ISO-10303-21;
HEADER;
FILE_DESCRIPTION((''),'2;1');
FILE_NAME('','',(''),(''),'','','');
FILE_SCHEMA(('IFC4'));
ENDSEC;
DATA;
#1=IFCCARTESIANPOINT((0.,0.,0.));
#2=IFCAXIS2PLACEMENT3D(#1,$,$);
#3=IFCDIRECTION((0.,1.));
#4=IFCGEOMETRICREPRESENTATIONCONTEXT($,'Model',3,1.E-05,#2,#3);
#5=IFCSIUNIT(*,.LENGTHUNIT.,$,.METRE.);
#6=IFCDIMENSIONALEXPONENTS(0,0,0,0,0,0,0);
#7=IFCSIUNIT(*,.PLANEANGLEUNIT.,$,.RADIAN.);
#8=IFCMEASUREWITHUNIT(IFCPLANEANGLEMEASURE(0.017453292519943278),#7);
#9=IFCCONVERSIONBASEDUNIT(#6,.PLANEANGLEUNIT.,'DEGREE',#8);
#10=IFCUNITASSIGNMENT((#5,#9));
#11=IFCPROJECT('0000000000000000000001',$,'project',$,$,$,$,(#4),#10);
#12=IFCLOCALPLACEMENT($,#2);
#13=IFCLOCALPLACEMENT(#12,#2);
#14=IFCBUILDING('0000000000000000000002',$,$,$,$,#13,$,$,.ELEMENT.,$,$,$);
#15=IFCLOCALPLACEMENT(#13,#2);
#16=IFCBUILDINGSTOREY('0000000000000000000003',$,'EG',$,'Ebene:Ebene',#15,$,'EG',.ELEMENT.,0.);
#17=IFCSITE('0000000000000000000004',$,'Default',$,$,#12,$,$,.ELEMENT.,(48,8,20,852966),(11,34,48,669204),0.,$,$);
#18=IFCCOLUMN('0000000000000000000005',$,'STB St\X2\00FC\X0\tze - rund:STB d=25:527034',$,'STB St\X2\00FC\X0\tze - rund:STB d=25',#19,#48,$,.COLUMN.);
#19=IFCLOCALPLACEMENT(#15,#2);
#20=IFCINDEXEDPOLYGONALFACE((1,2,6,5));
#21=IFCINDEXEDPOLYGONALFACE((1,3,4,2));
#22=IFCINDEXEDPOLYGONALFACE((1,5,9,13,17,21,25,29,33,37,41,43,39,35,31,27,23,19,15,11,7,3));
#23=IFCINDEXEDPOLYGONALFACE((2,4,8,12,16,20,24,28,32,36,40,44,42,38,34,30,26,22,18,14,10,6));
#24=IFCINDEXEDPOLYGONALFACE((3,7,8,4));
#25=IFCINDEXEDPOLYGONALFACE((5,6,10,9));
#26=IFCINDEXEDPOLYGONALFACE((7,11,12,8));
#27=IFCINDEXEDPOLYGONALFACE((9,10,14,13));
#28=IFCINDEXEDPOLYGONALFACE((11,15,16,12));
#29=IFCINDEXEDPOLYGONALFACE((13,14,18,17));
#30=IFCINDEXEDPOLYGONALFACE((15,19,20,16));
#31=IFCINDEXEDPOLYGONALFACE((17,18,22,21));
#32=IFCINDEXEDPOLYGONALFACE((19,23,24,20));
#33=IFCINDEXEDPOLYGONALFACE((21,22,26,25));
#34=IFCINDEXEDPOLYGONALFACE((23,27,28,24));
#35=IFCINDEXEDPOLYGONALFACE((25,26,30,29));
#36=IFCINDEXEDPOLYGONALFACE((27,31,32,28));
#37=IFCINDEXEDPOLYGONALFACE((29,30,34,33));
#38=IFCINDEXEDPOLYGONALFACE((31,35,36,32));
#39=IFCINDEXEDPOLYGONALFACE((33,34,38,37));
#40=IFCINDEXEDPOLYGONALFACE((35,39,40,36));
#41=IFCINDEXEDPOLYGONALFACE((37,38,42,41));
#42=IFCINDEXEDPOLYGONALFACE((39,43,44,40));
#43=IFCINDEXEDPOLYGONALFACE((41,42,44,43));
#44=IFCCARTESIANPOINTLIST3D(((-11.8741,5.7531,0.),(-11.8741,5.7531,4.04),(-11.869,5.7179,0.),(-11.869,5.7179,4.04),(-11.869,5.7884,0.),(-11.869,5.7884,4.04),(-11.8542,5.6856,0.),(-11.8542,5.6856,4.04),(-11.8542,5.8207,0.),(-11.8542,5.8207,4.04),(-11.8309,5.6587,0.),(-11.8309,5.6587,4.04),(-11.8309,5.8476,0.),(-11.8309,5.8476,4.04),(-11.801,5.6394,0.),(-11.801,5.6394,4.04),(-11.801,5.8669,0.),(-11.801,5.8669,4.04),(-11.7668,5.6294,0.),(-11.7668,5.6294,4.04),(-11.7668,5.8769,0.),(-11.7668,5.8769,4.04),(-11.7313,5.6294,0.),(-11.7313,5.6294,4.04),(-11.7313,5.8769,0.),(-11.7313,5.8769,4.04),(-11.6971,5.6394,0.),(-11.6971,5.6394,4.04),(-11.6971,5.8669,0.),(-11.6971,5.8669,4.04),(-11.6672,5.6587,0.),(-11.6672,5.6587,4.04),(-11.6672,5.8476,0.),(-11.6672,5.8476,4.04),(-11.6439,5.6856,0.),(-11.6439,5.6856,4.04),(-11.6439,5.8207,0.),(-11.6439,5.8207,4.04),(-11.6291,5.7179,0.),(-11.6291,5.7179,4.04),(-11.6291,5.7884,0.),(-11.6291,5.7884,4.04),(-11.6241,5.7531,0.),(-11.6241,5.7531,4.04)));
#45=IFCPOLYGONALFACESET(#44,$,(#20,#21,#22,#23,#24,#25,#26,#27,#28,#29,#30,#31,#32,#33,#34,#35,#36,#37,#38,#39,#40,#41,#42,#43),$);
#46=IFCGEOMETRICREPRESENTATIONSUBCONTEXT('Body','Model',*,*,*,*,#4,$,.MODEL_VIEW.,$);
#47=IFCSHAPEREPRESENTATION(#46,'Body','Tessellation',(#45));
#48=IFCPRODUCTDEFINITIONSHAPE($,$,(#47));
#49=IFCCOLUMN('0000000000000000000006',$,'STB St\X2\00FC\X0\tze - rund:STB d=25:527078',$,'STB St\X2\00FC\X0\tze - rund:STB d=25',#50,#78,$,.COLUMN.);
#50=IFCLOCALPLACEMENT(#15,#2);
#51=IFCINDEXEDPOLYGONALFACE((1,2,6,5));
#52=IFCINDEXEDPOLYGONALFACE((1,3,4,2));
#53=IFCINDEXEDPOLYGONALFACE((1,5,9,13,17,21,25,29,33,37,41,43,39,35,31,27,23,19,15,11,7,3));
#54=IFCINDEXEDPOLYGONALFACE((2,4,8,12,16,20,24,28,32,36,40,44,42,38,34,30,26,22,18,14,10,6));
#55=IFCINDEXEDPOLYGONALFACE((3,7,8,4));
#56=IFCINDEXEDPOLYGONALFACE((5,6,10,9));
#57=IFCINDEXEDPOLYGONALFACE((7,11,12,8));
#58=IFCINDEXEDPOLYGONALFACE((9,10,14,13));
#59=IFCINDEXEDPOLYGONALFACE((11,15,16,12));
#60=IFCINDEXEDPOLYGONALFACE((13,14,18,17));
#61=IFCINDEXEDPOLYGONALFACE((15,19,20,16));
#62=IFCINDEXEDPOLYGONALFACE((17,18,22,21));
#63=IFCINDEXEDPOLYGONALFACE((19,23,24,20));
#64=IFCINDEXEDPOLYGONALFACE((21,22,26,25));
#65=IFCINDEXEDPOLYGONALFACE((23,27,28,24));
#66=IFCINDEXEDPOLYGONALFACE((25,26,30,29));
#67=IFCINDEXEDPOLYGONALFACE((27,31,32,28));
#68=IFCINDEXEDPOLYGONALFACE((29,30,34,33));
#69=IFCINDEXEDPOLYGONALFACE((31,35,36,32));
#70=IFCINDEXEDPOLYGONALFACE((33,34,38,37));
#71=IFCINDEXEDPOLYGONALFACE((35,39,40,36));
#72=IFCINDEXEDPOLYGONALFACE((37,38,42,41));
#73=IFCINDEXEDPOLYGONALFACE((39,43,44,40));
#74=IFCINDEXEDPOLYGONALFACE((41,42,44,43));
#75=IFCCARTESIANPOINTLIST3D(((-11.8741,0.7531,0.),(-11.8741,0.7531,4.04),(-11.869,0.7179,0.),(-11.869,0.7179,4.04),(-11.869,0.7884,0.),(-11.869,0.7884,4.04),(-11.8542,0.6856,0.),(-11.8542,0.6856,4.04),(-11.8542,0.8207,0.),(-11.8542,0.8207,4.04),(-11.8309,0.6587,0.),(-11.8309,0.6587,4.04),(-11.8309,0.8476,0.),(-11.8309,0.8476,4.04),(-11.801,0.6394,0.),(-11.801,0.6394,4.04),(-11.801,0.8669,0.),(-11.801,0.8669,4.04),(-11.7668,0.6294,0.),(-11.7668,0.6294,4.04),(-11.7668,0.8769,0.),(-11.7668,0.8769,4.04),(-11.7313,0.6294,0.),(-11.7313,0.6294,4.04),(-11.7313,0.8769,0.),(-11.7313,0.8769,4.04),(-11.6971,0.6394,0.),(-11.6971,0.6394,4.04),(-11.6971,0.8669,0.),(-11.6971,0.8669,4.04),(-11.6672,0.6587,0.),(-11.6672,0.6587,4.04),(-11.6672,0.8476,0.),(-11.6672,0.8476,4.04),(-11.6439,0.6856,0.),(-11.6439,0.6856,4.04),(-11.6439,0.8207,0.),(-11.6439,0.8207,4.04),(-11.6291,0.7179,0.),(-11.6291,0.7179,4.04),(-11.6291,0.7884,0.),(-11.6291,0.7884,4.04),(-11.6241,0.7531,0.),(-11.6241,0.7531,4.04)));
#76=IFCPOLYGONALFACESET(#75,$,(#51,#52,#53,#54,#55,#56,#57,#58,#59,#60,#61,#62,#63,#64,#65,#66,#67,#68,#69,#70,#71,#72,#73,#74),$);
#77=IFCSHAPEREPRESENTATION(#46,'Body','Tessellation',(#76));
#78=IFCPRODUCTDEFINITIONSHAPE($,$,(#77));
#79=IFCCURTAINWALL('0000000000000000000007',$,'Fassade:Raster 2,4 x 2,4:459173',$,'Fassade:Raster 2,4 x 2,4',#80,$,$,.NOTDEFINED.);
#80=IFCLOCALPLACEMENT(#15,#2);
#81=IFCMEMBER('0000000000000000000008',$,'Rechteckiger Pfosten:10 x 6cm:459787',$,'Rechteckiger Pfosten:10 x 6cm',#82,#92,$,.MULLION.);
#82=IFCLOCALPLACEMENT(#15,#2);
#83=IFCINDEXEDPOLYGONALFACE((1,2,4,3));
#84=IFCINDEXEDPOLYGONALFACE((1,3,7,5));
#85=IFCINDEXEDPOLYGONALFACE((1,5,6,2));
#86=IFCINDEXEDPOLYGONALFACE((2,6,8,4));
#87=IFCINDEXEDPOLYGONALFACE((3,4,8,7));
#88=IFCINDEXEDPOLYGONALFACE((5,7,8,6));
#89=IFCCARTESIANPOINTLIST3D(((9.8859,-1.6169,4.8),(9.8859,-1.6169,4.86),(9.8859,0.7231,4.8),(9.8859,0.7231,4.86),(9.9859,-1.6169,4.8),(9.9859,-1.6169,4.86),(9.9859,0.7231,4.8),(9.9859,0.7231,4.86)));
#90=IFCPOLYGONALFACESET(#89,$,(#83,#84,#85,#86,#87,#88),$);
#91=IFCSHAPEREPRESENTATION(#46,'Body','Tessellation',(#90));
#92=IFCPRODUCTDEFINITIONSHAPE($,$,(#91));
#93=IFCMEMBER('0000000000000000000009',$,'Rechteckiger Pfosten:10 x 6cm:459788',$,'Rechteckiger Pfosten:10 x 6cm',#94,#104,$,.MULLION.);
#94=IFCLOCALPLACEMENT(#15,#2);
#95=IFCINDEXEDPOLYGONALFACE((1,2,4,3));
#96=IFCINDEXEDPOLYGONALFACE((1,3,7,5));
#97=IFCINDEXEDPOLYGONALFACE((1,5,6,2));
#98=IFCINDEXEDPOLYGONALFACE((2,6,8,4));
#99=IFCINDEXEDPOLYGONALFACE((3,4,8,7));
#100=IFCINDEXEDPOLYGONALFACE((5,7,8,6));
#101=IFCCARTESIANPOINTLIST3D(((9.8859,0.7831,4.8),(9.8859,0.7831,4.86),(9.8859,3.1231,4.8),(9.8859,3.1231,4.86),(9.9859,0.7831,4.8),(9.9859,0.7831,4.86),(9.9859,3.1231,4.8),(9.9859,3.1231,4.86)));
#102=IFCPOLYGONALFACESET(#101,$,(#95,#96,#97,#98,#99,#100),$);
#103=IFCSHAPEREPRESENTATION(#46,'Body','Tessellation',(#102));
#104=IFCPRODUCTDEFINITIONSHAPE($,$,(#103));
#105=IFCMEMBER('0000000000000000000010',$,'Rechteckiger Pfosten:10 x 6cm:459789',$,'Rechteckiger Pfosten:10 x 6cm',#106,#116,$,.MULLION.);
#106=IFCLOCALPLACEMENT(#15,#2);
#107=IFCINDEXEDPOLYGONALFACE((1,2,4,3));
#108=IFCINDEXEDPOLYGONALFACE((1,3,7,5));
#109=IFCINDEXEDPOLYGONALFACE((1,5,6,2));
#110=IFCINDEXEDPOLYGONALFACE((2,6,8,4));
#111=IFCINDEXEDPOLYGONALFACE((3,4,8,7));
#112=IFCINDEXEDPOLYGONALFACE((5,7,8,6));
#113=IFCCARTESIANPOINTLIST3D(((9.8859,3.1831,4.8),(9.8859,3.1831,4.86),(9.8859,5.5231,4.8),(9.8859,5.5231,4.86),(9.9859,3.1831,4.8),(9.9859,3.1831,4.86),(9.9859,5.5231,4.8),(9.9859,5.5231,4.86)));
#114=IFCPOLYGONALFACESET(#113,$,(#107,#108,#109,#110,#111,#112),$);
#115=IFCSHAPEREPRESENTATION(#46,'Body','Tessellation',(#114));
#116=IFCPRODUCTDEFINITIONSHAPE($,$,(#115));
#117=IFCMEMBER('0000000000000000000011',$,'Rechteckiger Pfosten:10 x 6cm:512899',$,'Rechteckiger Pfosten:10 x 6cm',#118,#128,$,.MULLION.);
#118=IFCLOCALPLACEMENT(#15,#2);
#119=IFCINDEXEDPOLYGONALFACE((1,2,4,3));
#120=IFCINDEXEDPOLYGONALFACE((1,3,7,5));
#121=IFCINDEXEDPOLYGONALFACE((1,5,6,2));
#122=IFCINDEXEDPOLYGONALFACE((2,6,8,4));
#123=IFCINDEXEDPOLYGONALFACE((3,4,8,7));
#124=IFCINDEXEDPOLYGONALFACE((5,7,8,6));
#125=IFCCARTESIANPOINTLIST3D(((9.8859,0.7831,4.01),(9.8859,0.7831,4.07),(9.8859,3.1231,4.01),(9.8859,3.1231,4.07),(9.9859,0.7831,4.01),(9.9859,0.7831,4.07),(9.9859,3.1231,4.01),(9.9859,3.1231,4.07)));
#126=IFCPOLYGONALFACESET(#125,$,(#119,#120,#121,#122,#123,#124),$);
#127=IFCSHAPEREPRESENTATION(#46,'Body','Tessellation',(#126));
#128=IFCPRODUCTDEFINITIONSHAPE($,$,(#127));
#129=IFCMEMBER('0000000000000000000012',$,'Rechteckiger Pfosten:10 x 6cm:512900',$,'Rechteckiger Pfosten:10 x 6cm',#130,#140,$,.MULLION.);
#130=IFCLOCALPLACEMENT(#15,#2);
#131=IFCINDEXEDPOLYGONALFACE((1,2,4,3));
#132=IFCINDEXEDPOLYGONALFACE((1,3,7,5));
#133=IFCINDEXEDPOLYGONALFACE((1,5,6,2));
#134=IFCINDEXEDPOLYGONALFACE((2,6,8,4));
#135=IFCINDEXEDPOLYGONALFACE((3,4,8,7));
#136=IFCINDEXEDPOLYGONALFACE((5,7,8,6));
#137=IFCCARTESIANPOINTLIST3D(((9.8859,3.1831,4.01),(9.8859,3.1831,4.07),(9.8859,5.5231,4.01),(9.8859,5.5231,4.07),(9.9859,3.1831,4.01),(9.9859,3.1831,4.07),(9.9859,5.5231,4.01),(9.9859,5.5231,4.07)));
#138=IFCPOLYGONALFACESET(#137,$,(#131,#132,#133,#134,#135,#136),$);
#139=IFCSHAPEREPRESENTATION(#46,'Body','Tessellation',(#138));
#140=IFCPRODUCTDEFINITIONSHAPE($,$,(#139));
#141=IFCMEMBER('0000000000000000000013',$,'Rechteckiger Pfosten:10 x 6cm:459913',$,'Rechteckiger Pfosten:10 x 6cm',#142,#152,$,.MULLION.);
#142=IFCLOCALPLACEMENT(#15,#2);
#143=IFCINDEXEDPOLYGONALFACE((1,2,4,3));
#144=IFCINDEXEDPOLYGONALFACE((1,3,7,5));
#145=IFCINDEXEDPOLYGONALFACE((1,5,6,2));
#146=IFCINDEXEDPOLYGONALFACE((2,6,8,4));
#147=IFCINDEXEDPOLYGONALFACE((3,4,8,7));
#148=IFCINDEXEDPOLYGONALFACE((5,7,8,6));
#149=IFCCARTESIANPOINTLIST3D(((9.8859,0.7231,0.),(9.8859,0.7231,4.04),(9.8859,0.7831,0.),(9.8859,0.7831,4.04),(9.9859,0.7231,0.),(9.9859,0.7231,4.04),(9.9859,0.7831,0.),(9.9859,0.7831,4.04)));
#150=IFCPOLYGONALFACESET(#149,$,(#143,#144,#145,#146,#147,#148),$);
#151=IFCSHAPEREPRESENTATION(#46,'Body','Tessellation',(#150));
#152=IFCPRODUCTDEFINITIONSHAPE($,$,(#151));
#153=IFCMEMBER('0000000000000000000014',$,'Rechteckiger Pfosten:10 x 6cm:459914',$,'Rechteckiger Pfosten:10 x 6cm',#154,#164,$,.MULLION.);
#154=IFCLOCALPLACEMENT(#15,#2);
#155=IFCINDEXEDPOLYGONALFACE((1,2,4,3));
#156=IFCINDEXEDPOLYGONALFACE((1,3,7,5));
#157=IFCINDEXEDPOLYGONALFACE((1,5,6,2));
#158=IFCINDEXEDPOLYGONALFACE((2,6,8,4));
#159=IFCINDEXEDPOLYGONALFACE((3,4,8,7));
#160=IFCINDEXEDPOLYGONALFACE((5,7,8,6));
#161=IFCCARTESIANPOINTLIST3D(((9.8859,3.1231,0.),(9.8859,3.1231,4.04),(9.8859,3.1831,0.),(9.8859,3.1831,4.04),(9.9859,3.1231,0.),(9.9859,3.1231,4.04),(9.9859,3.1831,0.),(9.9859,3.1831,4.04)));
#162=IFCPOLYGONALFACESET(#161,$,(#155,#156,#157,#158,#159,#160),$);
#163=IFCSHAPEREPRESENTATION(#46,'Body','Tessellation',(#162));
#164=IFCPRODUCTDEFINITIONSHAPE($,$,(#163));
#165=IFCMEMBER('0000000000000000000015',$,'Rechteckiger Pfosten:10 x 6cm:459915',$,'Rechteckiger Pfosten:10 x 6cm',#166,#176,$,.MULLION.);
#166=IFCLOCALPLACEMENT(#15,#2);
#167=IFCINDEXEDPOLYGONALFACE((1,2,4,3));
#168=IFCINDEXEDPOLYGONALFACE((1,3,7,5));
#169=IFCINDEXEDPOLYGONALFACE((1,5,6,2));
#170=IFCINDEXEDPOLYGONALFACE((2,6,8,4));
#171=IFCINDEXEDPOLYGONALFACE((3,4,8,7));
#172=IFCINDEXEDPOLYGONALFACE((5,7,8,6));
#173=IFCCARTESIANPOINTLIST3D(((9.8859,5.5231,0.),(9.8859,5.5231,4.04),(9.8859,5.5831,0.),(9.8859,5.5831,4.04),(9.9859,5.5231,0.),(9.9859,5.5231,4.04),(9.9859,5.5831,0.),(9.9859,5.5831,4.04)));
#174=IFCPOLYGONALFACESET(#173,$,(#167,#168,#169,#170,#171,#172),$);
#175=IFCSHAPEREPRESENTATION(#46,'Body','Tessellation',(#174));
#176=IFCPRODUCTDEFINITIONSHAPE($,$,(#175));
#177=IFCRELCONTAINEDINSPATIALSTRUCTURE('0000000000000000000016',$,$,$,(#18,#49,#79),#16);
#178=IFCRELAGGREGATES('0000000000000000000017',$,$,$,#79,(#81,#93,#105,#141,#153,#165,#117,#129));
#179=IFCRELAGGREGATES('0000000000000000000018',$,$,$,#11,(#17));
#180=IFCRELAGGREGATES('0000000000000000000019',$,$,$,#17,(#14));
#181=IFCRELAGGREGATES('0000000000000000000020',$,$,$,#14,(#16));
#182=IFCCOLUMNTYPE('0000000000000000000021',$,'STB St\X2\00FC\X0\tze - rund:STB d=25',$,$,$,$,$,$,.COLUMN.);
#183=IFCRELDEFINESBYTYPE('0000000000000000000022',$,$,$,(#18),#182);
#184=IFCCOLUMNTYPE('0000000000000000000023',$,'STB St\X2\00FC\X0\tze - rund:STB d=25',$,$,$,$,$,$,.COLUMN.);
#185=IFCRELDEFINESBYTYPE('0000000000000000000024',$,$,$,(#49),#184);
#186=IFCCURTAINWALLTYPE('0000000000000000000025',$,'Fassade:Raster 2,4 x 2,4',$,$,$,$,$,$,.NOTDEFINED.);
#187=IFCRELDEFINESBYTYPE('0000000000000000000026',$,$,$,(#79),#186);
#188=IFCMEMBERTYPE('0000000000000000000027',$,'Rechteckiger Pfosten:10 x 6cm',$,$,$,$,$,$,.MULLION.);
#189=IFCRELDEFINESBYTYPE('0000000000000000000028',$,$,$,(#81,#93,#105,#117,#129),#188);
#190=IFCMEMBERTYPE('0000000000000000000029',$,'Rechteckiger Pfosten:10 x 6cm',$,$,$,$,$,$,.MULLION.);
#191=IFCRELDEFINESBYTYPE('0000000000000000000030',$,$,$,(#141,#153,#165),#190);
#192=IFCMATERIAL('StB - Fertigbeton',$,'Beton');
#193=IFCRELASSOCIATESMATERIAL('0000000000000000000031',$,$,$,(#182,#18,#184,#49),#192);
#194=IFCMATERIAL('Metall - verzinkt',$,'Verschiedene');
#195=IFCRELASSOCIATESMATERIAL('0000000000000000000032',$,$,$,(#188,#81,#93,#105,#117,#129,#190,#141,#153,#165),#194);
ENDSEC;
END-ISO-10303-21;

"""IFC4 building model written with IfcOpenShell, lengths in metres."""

from ifc_helpers import new_model, entity, si_unit, converted_unit, direction, frame, origin, place, context, subcontext, project, spatial, arc, indexed_curve, outline, extrude, source, transform, mapped, material, type_object, type_shapes, element, aggregate, save


model = new_model("IFC4")

# Units and contexts
model_context = context("Model", 3, precision=1e-05, world=origin(), true_north=direction((0.0, 1.0)))
body_context = subcontext(model_context, "Body", "Model", "MODEL_VIEW")
ifc_project = project(units=[si_unit("LENGTHUNIT", "METRE"), converted_unit("PLANEANGLEUNIT", "DEGREE", entity("IfcPlaneAngleMeasure", 0.017453292519943278), si_unit("PLANEANGLEUNIT", "RADIAN"), dimensions=[0, 0, 0, 0, 0, 0, 0])], contexts=[model_context])

# Site, building, storey
site_placement = place(None, origin())
site = spatial("IfcSite", under=ifc_project, at=site_placement, Name="Default", CompositionType="ELEMENT", RefLatitude=(48, 8, 20, 852966), RefLongitude=(11, 34, 48, 669204), RefElevation=0.0)
building_placement = place(site_placement, origin())
building = spatial("IfcBuilding", under=site, at=building_placement, CompositionType="ELEMENT")
storey_placement = place(building_placement, origin())
storey = spatial("IfcBuildingStorey", under=building, at=storey_placement, Name="EG", ObjectType="Ebene:Ebene", LongName="EG", CompositionType="ELEMENT", Elevation=0.0)

# Columns
ifc_material_1 = material(Name="StB - Fertigbeton", Category="Beton")
column_type_1 = type_object("IfcColumnType", Name="STB Stütze - rund:STB d=25", PredefinedType="COLUMN", material=ifc_material_1)
shared_shape_1 = source(origin(), body_context, "Body", "SweptSolid", [
    extrude(outline(indexed_curve([(-0.125, 0.0), (0.0, -0.125), (0.125, 0.0), (0.0, 0.125)], segments=[arc(1, 2, 3), arc(3, 4, 1)], self_intersect=False)), frame((-11.7491, 5.7531, 0.0), z_axis=(0.0, 0.0, 1.0), x_axis=(-1.0, 0.0, 0.0)), (0.0, 0.0, 1.0), 4.04),
])
type_shapes(column_type_1, [shared_shape_1])
column_1_placement = place(storey_placement, origin())
element("IfcColumn", 1, at=column_1_placement, inside=storey, type_object=column_type_1, material=ifc_material_1, Name="STB Stütze - rund:STB d=25:527034", ObjectType="STB Stütze - rund:STB d=25", PredefinedType="COLUMN", context=body_context, shape_type="MappedRepresentation", body=[
    mapped(shared_shape_1, transform((0.0, 0.0, 0.0), scale=1.0)),
])
column_type_2 = type_object("IfcColumnType", Name="STB Stütze - rund:STB d=25", PredefinedType="COLUMN", material=ifc_material_1)
shared_shape_2 = source(origin(), body_context, "Body", "SweptSolid", [
    extrude(outline(indexed_curve([(-0.125, 0.0), (0.0, -0.125), (0.125, 0.0), (0.0, 0.125)], segments=[arc(1, 2, 3), arc(3, 4, 1)], self_intersect=False)), frame((-11.7491, 0.7531, 0.0), z_axis=(0.0, 0.0, 1.0), x_axis=(-1.0, 0.0, 0.0)), (0.0, 0.0, 1.0), 4.04),
])
type_shapes(column_type_2, [shared_shape_2])
column_2_placement = place(storey_placement, origin())
element("IfcColumn", 2, at=column_2_placement, inside=storey, type_object=column_type_2, material=ifc_material_1, Name="STB Stütze - rund:STB d=25:527078", ObjectType="STB Stütze - rund:STB d=25", PredefinedType="COLUMN", context=body_context, shape_type="MappedRepresentation", body=[
    mapped(shared_shape_2, transform((0.0, 0.0, 0.0), scale=1.0)),
])

# Curtain wall, members
curtain_wall_type = type_object("IfcCurtainWallType", Name="Fassade:Raster 2,4 x 2,4", PredefinedType="NOTDEFINED")
curtain_wall_placement = place(storey_placement, origin())
curtain_wall = element("IfcCurtainWall", 3, at=curtain_wall_placement, inside=storey, type_object=curtain_wall_type, Name="Fassade:Raster 2,4 x 2,4:459173", ObjectType="Fassade:Raster 2,4 x 2,4", PredefinedType="NOTDEFINED")
ifc_material_2 = material(Name="Metall - verzinkt", Category="Verschiedene")
member_type_1 = type_object("IfcMemberType", Name="Rechteckiger Pfosten:10 x 6cm", PredefinedType="MULLION", material=ifc_material_2)
shared_shape_3 = source(origin(), body_context, "Body", "SweptSolid", [
    extrude(outline(indexed_curve([(-0.03, -0.05), (0.03, -0.05), (0.03, 0.05), (-0.03, 0.05), (-0.03, -0.05)], self_intersect=False)), frame((0.0, 0.0, -2.34), z_axis=(0.0, 0.0, 1.0), x_axis=(-1.0, 0.0, 0.0)), (0.0, 0.0, 1.0), 2.34),
])
type_shapes(member_type_1, [shared_shape_3])
member_1_placement = place(curtain_wall_placement, frame((9.9359, 0.7231, 4.83), z_axis=(0.0, 1.0, 0.0), x_axis=(0.0, 0.0, 1.0)))
member_1 = element("IfcMember", 4, at=member_1_placement, type_object=member_type_1, material=ifc_material_2, Name="Rechteckiger Pfosten:10 x 6cm:459787", ObjectType="Rechteckiger Pfosten:10 x 6cm", PredefinedType="MULLION", context=body_context, shape_type="MappedRepresentation", body=[
    mapped(shared_shape_3, transform((0.0, 0.0, 0.0), scale=1.0)),
])
member_2_placement = place(curtain_wall_placement, frame((9.9359, 3.1231, 4.83), z_axis=(0.0, 1.0, 0.0), x_axis=(0.0, 0.0, 1.0)))
member_2 = element("IfcMember", 5, at=member_2_placement, type_object=member_type_1, material=ifc_material_2, Name="Rechteckiger Pfosten:10 x 6cm:459788", ObjectType="Rechteckiger Pfosten:10 x 6cm", PredefinedType="MULLION", context=body_context, shape_type="MappedRepresentation", body=[
    mapped(shared_shape_3, transform((0.0, 0.0, 0.0), scale=1.0)),
])
member_3_placement = place(curtain_wall_placement, frame((9.9359, 5.5231, 4.83), z_axis=(0.0, 1.0, 0.0), x_axis=(0.0, 0.0, 1.0)))
member_3 = element("IfcMember", 6, at=member_3_placement, type_object=member_type_1, material=ifc_material_2, Name="Rechteckiger Pfosten:10 x 6cm:459789", ObjectType="Rechteckiger Pfosten:10 x 6cm", PredefinedType="MULLION", context=body_context, shape_type="MappedRepresentation", body=[
    mapped(shared_shape_3, transform((0.0, 0.0, 0.0), scale=1.0)),
])
member_4_placement = place(curtain_wall_placement, frame((9.9359, 3.1231, 4.04), z_axis=(0.0, 1.0, 0.0), x_axis=(0.0, 0.0, 1.0)))
member_4 = element("IfcMember", 7, at=member_4_placement, type_object=member_type_1, material=ifc_material_2, Name="Rechteckiger Pfosten:10 x 6cm:512899", ObjectType="Rechteckiger Pfosten:10 x 6cm", PredefinedType="MULLION", context=body_context, shape_type="MappedRepresentation", body=[
    mapped(shared_shape_3, transform((0.0, 0.0, 0.0), scale=1.0)),
])
member_5_placement = place(curtain_wall_placement, frame((9.9359, 5.5231, 4.04), z_axis=(0.0, 1.0, 0.0), x_axis=(0.0, 0.0, 1.0)))
member_5 = element("IfcMember", 8, at=member_5_placement, type_object=member_type_1, material=ifc_material_2, Name="Rechteckiger Pfosten:10 x 6cm:512900", ObjectType="Rechteckiger Pfosten:10 x 6cm", PredefinedType="MULLION", context=body_context, shape_type="MappedRepresentation", body=[
    mapped(shared_shape_3, transform((0.0, 0.0, 0.0), scale=1.0)),
])
member_type_2 = type_object("IfcMemberType", Name="Rechteckiger Pfosten:10 x 6cm", PredefinedType="MULLION", material=ifc_material_2)
shared_shape_4 = source(origin(), body_context, "Body", "SweptSolid", [
    extrude(outline(indexed_curve([(-0.03, -0.05), (0.03, -0.05), (0.03, 0.05), (-0.03, 0.05), (-0.03, -0.05)], self_intersect=False)), frame((0.0, 0.0, -4.04), z_axis=(0.0, 0.0, 1.0), x_axis=(-1.0, 0.0, 0.0)), (0.0, 0.0, 1.0), 4.04),
])
type_shapes(member_type_2, [shared_shape_4])
member_6_placement = place(curtain_wall_placement, frame((9.9359, 0.7531, 0.0), z_axis=(0.0, 0.0, -1.0), x_axis=(0.0, 1.0, 0.0)))
member_6 = element("IfcMember", 9, at=member_6_placement, type_object=member_type_2, material=ifc_material_2, Name="Rechteckiger Pfosten:10 x 6cm:459913", ObjectType="Rechteckiger Pfosten:10 x 6cm", PredefinedType="MULLION", context=body_context, shape_type="MappedRepresentation", body=[
    mapped(shared_shape_4, transform((0.0, 0.0, 0.0), scale=1.0)),
])
member_7_placement = place(curtain_wall_placement, frame((9.9359, 3.1531, 0.0), z_axis=(0.0, 0.0, -1.0), x_axis=(0.0, 1.0, 0.0)))
member_7 = element("IfcMember", 10, at=member_7_placement, type_object=member_type_2, material=ifc_material_2, Name="Rechteckiger Pfosten:10 x 6cm:459914", ObjectType="Rechteckiger Pfosten:10 x 6cm", PredefinedType="MULLION", context=body_context, shape_type="MappedRepresentation", body=[
    mapped(shared_shape_4, transform((0.0, 0.0, 0.0), scale=1.0)),
])
member_8_placement = place(curtain_wall_placement, frame((9.9359, 5.5531, 0.0), z_axis=(0.0, 0.0, -1.0), x_axis=(0.0, 1.0, 0.0)))
member_8 = element("IfcMember", 11, at=member_8_placement, type_object=member_type_2, material=ifc_material_2, Name="Rechteckiger Pfosten:10 x 6cm:459915", ObjectType="Rechteckiger Pfosten:10 x 6cm", PredefinedType="MULLION", context=body_context, shape_type="MappedRepresentation", body=[
    mapped(shared_shape_4, transform((0.0, 0.0, 0.0), scale=1.0)),
])

aggregate(curtain_wall, [member_1, member_2, member_3, member_6, member_7, member_8, member_4, member_5])

save(model, "model.ifc")
